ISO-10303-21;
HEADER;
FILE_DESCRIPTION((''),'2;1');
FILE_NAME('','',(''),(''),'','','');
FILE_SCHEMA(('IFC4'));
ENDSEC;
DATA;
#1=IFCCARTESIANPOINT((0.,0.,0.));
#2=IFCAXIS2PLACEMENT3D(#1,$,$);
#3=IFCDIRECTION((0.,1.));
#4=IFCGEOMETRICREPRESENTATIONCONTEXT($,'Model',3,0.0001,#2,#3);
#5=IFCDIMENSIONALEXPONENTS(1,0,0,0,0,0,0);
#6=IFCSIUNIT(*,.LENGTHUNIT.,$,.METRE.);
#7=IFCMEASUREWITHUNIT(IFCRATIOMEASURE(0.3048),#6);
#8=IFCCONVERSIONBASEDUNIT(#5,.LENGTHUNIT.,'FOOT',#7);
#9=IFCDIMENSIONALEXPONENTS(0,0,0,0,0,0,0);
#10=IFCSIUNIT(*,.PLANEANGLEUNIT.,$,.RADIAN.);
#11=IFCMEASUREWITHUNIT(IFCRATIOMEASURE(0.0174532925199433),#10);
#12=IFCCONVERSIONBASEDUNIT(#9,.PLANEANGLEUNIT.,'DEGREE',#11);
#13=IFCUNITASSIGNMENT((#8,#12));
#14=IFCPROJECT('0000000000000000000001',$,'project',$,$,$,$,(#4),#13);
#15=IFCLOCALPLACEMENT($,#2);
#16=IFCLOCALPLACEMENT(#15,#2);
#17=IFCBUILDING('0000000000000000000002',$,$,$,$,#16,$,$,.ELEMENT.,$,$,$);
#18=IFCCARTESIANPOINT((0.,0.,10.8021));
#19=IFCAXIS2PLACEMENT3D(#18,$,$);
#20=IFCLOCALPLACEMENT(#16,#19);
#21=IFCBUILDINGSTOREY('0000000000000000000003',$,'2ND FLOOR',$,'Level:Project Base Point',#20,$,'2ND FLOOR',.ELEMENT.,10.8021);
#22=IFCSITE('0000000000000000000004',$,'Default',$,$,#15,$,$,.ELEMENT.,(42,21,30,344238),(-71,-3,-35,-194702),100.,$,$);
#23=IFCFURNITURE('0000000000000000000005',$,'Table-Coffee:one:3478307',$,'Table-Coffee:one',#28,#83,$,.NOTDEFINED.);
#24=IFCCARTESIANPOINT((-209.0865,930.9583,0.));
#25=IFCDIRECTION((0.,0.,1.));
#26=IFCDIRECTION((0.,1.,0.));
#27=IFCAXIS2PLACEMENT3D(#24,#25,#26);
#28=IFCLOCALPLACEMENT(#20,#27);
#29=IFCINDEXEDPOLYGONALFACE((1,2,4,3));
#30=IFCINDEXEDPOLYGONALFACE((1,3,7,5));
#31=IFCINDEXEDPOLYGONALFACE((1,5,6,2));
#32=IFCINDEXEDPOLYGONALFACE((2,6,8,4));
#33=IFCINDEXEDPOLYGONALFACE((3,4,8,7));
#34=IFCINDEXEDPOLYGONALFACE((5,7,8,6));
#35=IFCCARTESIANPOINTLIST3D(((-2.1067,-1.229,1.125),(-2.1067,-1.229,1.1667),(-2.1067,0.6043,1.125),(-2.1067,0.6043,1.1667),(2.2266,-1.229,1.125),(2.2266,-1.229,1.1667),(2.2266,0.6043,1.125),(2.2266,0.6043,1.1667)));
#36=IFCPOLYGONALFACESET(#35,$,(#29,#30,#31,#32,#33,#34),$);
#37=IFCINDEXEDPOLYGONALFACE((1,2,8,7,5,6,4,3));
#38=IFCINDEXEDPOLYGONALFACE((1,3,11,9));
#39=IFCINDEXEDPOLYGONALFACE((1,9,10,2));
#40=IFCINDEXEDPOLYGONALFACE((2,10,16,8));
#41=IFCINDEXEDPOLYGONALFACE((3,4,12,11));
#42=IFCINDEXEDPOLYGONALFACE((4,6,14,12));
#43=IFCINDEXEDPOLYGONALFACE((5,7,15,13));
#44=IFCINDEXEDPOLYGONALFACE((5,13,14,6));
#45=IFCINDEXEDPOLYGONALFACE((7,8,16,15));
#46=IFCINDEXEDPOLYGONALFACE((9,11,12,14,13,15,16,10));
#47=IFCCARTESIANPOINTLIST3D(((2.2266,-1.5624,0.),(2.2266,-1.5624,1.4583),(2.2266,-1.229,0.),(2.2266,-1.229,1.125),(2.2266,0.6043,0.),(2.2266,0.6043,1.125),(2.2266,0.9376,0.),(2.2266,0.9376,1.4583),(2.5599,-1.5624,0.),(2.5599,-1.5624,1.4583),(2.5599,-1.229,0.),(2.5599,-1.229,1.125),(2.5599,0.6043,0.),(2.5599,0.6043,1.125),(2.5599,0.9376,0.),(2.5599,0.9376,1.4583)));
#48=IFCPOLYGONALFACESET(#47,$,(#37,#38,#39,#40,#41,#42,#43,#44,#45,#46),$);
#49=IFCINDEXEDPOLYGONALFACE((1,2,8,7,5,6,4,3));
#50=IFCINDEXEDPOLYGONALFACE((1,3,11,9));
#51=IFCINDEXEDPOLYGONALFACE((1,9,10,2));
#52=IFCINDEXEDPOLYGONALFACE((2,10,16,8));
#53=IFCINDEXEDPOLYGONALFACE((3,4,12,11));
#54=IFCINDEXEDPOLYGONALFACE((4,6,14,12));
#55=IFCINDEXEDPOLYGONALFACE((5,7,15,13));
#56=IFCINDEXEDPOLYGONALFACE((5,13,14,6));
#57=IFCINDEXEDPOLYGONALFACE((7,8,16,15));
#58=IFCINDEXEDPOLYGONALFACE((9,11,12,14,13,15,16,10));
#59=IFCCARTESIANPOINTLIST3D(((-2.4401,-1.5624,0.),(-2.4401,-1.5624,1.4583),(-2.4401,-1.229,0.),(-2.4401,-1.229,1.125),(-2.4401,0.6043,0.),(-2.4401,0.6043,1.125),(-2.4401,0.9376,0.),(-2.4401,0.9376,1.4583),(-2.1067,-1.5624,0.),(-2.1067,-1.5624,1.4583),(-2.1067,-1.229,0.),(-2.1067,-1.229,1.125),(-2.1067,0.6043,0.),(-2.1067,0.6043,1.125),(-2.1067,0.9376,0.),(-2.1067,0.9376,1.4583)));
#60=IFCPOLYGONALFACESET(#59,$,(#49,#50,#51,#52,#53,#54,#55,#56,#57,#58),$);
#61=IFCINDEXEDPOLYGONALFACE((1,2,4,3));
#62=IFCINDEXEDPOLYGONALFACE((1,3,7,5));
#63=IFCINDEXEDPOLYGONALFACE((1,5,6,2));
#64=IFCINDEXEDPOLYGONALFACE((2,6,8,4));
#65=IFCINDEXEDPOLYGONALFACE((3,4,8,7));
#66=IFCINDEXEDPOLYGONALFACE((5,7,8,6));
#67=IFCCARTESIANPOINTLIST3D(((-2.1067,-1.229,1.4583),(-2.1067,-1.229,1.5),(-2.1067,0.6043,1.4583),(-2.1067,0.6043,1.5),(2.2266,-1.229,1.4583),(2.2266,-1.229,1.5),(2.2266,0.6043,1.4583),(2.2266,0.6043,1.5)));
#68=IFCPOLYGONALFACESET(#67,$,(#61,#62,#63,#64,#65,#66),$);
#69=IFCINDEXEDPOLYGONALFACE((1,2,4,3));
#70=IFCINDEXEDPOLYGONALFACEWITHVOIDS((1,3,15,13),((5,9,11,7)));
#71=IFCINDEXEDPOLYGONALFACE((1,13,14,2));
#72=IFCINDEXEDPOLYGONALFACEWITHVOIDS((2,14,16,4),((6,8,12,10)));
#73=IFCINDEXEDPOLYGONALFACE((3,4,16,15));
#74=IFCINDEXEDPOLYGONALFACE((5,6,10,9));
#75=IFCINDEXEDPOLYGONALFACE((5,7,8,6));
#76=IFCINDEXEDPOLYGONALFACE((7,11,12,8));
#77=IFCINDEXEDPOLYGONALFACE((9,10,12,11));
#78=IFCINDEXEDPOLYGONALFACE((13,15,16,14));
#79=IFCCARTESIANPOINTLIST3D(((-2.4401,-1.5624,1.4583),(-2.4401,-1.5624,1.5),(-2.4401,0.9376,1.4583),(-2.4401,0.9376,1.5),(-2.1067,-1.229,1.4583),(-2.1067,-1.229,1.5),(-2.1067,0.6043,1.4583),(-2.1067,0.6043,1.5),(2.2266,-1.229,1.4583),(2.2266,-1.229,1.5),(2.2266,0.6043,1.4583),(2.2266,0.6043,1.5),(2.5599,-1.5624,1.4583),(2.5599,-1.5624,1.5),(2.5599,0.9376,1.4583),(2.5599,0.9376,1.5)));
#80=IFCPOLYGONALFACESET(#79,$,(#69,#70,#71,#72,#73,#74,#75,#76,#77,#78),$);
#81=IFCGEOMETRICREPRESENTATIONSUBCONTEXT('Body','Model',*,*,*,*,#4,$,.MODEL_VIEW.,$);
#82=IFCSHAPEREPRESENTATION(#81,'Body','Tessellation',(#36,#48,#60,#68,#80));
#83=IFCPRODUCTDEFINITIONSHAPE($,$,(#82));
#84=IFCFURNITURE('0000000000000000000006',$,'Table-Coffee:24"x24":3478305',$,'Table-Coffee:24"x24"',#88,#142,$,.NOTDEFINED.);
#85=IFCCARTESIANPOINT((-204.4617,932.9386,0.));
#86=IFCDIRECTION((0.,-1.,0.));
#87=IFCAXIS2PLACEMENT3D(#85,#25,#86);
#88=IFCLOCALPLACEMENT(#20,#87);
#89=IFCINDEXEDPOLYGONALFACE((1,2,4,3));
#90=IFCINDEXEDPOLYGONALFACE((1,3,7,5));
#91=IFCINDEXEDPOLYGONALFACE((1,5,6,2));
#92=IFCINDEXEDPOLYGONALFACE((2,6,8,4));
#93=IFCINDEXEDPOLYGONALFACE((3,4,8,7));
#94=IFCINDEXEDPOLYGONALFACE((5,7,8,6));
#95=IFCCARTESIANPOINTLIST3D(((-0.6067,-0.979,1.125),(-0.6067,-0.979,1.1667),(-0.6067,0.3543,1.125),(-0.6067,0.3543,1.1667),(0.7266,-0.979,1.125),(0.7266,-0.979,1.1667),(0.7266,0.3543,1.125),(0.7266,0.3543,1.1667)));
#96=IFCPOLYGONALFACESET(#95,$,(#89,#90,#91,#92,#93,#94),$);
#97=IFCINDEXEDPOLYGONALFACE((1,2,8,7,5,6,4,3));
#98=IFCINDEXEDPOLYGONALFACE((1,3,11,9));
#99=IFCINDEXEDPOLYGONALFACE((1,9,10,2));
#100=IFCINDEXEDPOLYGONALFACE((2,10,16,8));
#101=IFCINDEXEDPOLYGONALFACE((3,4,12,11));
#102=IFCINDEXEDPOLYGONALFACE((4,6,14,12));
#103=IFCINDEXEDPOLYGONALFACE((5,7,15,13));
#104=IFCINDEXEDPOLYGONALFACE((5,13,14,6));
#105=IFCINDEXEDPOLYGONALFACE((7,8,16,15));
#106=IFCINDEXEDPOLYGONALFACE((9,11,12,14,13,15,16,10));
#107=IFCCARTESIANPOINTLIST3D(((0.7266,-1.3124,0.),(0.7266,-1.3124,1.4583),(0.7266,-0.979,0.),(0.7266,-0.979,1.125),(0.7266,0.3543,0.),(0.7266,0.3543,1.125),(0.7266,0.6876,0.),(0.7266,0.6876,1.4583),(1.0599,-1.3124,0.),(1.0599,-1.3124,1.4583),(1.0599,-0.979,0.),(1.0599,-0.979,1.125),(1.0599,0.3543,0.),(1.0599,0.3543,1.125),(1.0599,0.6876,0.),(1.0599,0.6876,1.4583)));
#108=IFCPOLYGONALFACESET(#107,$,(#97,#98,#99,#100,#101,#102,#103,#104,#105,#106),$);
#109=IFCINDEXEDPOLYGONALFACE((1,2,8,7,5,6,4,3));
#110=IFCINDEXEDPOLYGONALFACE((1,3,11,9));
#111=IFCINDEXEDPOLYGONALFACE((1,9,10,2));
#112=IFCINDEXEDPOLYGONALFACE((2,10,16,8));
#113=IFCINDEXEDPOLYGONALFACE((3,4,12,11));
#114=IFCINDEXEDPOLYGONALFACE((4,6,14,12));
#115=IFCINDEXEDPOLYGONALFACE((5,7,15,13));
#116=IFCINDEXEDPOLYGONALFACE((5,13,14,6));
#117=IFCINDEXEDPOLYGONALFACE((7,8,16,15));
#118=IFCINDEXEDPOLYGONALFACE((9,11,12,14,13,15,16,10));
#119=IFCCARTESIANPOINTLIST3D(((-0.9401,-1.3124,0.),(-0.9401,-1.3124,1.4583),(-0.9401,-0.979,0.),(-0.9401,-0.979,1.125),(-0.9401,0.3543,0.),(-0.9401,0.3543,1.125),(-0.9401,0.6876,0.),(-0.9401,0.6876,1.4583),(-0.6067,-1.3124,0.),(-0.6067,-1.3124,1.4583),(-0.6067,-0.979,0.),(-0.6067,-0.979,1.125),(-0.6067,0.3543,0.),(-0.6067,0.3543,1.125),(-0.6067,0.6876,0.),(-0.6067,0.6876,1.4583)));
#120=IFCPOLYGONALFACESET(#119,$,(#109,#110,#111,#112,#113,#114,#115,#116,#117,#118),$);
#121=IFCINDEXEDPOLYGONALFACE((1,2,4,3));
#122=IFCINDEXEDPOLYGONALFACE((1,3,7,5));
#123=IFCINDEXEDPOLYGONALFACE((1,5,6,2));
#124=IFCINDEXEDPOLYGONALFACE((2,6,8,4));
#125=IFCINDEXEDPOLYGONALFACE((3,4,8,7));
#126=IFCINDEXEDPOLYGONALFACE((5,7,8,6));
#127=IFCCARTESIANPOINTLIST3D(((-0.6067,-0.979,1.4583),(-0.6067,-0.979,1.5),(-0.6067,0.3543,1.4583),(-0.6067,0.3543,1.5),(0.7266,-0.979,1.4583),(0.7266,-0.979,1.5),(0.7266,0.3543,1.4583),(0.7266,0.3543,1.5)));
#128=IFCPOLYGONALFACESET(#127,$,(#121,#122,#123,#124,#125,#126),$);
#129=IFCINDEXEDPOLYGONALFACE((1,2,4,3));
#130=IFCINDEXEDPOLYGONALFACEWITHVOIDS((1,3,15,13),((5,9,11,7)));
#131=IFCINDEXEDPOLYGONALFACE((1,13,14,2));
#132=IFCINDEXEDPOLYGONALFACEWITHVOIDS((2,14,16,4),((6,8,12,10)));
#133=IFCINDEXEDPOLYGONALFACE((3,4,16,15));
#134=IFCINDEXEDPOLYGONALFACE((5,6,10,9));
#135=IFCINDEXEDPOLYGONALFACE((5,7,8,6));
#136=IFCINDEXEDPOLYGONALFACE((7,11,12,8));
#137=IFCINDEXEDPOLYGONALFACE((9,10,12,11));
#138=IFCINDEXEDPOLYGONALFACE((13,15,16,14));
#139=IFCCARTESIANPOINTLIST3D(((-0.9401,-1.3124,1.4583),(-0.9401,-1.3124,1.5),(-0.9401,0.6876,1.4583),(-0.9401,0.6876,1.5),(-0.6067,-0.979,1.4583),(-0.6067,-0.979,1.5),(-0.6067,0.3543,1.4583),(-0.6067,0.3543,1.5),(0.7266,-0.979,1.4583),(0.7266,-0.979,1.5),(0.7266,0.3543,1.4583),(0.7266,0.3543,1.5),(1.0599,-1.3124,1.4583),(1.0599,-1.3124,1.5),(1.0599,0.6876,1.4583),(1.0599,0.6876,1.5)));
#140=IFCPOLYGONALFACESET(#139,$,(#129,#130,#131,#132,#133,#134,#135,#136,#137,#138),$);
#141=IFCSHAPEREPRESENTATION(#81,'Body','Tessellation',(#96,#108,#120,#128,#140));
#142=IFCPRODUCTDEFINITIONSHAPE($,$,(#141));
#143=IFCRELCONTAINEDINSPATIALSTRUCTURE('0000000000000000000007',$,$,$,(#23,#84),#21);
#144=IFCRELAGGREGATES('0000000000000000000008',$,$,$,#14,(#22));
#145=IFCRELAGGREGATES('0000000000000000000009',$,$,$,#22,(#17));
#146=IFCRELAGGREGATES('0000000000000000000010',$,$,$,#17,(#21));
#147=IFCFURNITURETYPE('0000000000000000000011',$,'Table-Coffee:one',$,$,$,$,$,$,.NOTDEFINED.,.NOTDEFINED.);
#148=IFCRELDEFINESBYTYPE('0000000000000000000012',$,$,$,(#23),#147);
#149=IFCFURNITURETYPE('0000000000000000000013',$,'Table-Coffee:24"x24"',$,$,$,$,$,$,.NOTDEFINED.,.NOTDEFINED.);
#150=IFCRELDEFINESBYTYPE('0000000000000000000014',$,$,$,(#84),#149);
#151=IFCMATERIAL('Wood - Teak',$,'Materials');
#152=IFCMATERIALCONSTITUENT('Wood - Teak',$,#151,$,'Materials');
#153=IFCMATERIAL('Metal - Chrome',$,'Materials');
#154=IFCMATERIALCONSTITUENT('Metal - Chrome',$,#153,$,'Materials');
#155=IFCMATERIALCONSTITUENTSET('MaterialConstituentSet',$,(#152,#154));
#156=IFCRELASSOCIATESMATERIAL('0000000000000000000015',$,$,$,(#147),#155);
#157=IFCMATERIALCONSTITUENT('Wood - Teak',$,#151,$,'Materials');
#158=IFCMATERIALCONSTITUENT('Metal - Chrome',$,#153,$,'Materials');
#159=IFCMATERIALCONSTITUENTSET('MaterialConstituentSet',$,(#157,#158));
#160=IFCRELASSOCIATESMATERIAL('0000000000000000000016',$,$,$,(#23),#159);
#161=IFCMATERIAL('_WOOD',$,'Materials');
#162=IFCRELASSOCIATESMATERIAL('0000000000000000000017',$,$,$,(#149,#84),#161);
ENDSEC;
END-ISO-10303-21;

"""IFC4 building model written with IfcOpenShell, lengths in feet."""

from ifc_helpers import new_model, entity, si_unit, converted_unit, direction, frame, origin, origin_2d_with_axis, place, context, subcontext, project, spatial, polyline, rectangle, outline, extrude, source, transform, mapped, material, constituent, constituent_set, type_object, type_shapes, element, save


model = new_model("IFC4")

# Units and contexts
model_context = context("Model", 3, precision=0.0001, world=origin(), true_north=direction((0.0, 1.0)))
body_context = subcontext(model_context, "Body", "Model", "MODEL_VIEW")
ifc_project = project(units=[converted_unit("LENGTHUNIT", "FOOT", entity("IfcRatioMeasure", 0.3048), si_unit("LENGTHUNIT", "METRE"), dimensions=[1, 0, 0, 0, 0, 0, 0]), converted_unit("PLANEANGLEUNIT", "DEGREE", entity("IfcRatioMeasure", 0.0174532925199433), si_unit("PLANEANGLEUNIT", "RADIAN"), dimensions=[0, 0, 0, 0, 0, 0, 0])], contexts=[model_context])

# Site, building, storey
site_placement = place(None, origin())
site = spatial("IfcSite", under=ifc_project, at=site_placement, Name="Default", CompositionType="ELEMENT", RefLatitude=(42, 21, 30, 344238), RefLongitude=(-71, -3, -35, -194702), RefElevation=100.0)
building_placement = place(site_placement, origin())
building = spatial("IfcBuilding", under=site, at=building_placement, CompositionType="ELEMENT")
storey_placement = place(building_placement, frame((0.0, 0.0, 10.8021)))
storey = spatial("IfcBuildingStorey", under=building, at=storey_placement, Name="2ND FLOOR", ObjectType="Level:Project Base Point", LongName="2ND FLOOR", CompositionType="ELEMENT", Elevation=10.8021)

# Furniture
ifc_material_1 = material(Name="Wood - Teak", Category="Materials")
ifc_constituent_1 = constituent(ifc_material_1, Name="Wood - Teak", Category="Materials")
ifc_material_2 = material(Name="Metal - Chrome", Category="Materials")
ifc_constituent_2 = constituent(ifc_material_2, Name="Metal - Chrome", Category="Materials")
ifc_constituent_set_1 = constituent_set(constituents=[ifc_constituent_1, ifc_constituent_2], Name="MaterialConstituentSet")
ifc_constituent_3 = constituent(ifc_material_1, Name="Wood - Teak", Category="Materials")
ifc_constituent_4 = constituent(ifc_material_2, Name="Metal - Chrome", Category="Materials")
ifc_constituent_set_2 = constituent_set(constituents=[ifc_constituent_3, ifc_constituent_4], Name="MaterialConstituentSet")
furniture_type_1 = type_object("IfcFurnitureType", Name="Table-Coffee:one", AssemblyPlace="NOTDEFINED", PredefinedType="NOTDEFINED", material=ifc_constituent_set_2)
shared_shape_1 = source(origin(), body_context, "Body", "SweptSolid", [
    extrude(rectangle(XDim=1.8333, YDim=4.3333, at=origin_2d_with_axis()), frame((0.0599, -0.3124, 1.125), z_axis=(0.0, 0.0, 1.0), x_axis=(0.0, 1.0, 0.0)), (0.0, 0.0, 1.0), 0.0417),
    extrude(outline(polyline([(-1.25, -0.6458), (-0.9167, -0.6458), (-0.9167, 0.4792), (0.9167, 0.4792), (0.9167, -0.6458), (1.25, -0.6458), (1.25, 0.8125), (-1.25, 0.8125), (-1.25, -0.6458)])), frame((2.2266, -0.3124, 0.6458), z_axis=(1.0, 0.0, 0.0), x_axis=(0.0, 1.0, 0.0)), (0.0, 0.0, 1.0), 0.3333),
    extrude(outline(polyline([(-0.8125, -1.25), (0.6458, -1.25), (0.6458, -0.9167), (-0.4792, -0.9167), (-0.4792, 0.9167), (0.6458, 0.9167), (0.6458, 1.25), (-0.8125, 1.25), (-0.8125, -1.25)])), frame((-2.4401, -0.3124, 0.6458), z_axis=(1.0, 0.0, 0.0), x_axis=(0.0, 0.0, -1.0)), (0.0, 0.0, 1.0), 0.3333),
    extrude(rectangle(XDim=1.8333, YDim=4.3333, at=origin_2d_with_axis()), frame((0.0599, -0.3124, 1.4583), z_axis=(0.0, 0.0, 1.0), x_axis=(0.0, 1.0, 0.0)), (0.0, 0.0, 1.0), 0.0417),
    extrude(outline(polyline([(-1.25, -2.5), (1.25, -2.5), (1.25, 2.5), (-1.25, 2.5), (-1.25, -2.5)]), holes=[polyline([(-0.9167, -2.1667), (-0.9167, 2.1667), (0.9167, 2.1667), (0.9167, -2.1667), (-0.9167, -2.1667)])]), frame((0.0599, -0.3124, 1.4583), z_axis=(0.0, 0.0, 1.0), x_axis=(0.0, 1.0, 0.0)), (0.0, 0.0, 1.0), 0.0417),
])
type_shapes(furniture_type_1, [shared_shape_1])
furniture_1_placement = place(storey_placement, frame((-209.0865, 930.9583, 0.0), z_axis=(0.0, 0.0, 1.0), x_axis=(0.0, 1.0, 0.0)))
element("IfcFurniture", 1, at=furniture_1_placement, inside=storey, type_object=furniture_type_1, material=ifc_constituent_set_1, Name="Table-Coffee:one:3478307", ObjectType="Table-Coffee:one", PredefinedType="NOTDEFINED", context=body_context, shape_type="MappedRepresentation", body=[
    mapped(shared_shape_1, transform((0.0, 0.0, 0.0), scale=1.0)),
])
ifc_material_3 = material(Name="_WOOD", Category="Materials")
furniture_type_2 = type_object("IfcFurnitureType", Name="Table-Coffee:24\"x24\"", AssemblyPlace="NOTDEFINED", PredefinedType="NOTDEFINED", material=ifc_material_3)
shared_shape_2 = source(origin(), body_context, "Body", "SweptSolid", [
    extrude(rectangle(XDim=1.3333, YDim=1.3333, at=origin_2d_with_axis()), frame((0.0599, -0.3124, 1.125), z_axis=(0.0, 0.0, 1.0), x_axis=(0.0, 1.0, 0.0)), (0.0, 0.0, 1.0), 0.0417),
    extrude(outline(polyline([(-1.0, -0.6458), (-0.6667, -0.6458), (-0.6667, 0.4792), (0.6667, 0.4792), (0.6667, -0.6458), (1.0, -0.6458), (1.0, 0.8125), (-1.0, 0.8125), (-1.0, -0.6458)])), frame((0.7266, -0.3124, 0.6458), z_axis=(1.0, 0.0, 0.0), x_axis=(0.0, 1.0, 0.0)), (0.0, 0.0, 1.0), 0.3333),
    extrude(outline(polyline([(-0.8125, -1.0), (0.6458, -1.0), (0.6458, -0.6667), (-0.4792, -0.6667), (-0.4792, 0.6667), (0.6458, 0.6667), (0.6458, 1.0), (-0.8125, 1.0), (-0.8125, -1.0)])), frame((-0.9401, -0.3124, 0.6458), z_axis=(1.0, 0.0, 0.0), x_axis=(0.0, 0.0, -1.0)), (0.0, 0.0, 1.0), 0.3333),
    extrude(rectangle(XDim=1.3333, YDim=1.3333, at=origin_2d_with_axis()), frame((0.0599, -0.3124, 1.4583), z_axis=(0.0, 0.0, 1.0), x_axis=(0.0, 1.0, 0.0)), (0.0, 0.0, 1.0), 0.0417),
    extrude(outline(polyline([(-1.0, -1.0), (1.0, -1.0), (1.0, 1.0), (-1.0, 1.0), (-1.0, -1.0)]), holes=[polyline([(-0.6667, -0.6667), (-0.6667, 0.6667), (0.6667, 0.6667), (0.6667, -0.6667), (-0.6667, -0.6667)])]), frame((0.0599, -0.3124, 1.4583), z_axis=(0.0, 0.0, 1.0), x_axis=(0.0, 1.0, 0.0)), (0.0, 0.0, 1.0), 0.0417),
])
type_shapes(furniture_type_2, [shared_shape_2])
furniture_2_placement = place(storey_placement, frame((-204.4617, 932.9386, 0.0), z_axis=(0.0, 0.0, 1.0), x_axis=(0.0, -1.0, 0.0)))
element("IfcFurniture", 2, at=furniture_2_placement, inside=storey, type_object=furniture_type_2, material=ifc_material_3, Name="Table-Coffee:24\"x24\":3478305", ObjectType="Table-Coffee:24\"x24\"", PredefinedType="NOTDEFINED", context=body_context, shape_type="MappedRepresentation", body=[
    mapped(shared_shape_2, transform((0.0, 0.0, 0.0), scale=1.0)),
])

save(model, "model.ifc")
